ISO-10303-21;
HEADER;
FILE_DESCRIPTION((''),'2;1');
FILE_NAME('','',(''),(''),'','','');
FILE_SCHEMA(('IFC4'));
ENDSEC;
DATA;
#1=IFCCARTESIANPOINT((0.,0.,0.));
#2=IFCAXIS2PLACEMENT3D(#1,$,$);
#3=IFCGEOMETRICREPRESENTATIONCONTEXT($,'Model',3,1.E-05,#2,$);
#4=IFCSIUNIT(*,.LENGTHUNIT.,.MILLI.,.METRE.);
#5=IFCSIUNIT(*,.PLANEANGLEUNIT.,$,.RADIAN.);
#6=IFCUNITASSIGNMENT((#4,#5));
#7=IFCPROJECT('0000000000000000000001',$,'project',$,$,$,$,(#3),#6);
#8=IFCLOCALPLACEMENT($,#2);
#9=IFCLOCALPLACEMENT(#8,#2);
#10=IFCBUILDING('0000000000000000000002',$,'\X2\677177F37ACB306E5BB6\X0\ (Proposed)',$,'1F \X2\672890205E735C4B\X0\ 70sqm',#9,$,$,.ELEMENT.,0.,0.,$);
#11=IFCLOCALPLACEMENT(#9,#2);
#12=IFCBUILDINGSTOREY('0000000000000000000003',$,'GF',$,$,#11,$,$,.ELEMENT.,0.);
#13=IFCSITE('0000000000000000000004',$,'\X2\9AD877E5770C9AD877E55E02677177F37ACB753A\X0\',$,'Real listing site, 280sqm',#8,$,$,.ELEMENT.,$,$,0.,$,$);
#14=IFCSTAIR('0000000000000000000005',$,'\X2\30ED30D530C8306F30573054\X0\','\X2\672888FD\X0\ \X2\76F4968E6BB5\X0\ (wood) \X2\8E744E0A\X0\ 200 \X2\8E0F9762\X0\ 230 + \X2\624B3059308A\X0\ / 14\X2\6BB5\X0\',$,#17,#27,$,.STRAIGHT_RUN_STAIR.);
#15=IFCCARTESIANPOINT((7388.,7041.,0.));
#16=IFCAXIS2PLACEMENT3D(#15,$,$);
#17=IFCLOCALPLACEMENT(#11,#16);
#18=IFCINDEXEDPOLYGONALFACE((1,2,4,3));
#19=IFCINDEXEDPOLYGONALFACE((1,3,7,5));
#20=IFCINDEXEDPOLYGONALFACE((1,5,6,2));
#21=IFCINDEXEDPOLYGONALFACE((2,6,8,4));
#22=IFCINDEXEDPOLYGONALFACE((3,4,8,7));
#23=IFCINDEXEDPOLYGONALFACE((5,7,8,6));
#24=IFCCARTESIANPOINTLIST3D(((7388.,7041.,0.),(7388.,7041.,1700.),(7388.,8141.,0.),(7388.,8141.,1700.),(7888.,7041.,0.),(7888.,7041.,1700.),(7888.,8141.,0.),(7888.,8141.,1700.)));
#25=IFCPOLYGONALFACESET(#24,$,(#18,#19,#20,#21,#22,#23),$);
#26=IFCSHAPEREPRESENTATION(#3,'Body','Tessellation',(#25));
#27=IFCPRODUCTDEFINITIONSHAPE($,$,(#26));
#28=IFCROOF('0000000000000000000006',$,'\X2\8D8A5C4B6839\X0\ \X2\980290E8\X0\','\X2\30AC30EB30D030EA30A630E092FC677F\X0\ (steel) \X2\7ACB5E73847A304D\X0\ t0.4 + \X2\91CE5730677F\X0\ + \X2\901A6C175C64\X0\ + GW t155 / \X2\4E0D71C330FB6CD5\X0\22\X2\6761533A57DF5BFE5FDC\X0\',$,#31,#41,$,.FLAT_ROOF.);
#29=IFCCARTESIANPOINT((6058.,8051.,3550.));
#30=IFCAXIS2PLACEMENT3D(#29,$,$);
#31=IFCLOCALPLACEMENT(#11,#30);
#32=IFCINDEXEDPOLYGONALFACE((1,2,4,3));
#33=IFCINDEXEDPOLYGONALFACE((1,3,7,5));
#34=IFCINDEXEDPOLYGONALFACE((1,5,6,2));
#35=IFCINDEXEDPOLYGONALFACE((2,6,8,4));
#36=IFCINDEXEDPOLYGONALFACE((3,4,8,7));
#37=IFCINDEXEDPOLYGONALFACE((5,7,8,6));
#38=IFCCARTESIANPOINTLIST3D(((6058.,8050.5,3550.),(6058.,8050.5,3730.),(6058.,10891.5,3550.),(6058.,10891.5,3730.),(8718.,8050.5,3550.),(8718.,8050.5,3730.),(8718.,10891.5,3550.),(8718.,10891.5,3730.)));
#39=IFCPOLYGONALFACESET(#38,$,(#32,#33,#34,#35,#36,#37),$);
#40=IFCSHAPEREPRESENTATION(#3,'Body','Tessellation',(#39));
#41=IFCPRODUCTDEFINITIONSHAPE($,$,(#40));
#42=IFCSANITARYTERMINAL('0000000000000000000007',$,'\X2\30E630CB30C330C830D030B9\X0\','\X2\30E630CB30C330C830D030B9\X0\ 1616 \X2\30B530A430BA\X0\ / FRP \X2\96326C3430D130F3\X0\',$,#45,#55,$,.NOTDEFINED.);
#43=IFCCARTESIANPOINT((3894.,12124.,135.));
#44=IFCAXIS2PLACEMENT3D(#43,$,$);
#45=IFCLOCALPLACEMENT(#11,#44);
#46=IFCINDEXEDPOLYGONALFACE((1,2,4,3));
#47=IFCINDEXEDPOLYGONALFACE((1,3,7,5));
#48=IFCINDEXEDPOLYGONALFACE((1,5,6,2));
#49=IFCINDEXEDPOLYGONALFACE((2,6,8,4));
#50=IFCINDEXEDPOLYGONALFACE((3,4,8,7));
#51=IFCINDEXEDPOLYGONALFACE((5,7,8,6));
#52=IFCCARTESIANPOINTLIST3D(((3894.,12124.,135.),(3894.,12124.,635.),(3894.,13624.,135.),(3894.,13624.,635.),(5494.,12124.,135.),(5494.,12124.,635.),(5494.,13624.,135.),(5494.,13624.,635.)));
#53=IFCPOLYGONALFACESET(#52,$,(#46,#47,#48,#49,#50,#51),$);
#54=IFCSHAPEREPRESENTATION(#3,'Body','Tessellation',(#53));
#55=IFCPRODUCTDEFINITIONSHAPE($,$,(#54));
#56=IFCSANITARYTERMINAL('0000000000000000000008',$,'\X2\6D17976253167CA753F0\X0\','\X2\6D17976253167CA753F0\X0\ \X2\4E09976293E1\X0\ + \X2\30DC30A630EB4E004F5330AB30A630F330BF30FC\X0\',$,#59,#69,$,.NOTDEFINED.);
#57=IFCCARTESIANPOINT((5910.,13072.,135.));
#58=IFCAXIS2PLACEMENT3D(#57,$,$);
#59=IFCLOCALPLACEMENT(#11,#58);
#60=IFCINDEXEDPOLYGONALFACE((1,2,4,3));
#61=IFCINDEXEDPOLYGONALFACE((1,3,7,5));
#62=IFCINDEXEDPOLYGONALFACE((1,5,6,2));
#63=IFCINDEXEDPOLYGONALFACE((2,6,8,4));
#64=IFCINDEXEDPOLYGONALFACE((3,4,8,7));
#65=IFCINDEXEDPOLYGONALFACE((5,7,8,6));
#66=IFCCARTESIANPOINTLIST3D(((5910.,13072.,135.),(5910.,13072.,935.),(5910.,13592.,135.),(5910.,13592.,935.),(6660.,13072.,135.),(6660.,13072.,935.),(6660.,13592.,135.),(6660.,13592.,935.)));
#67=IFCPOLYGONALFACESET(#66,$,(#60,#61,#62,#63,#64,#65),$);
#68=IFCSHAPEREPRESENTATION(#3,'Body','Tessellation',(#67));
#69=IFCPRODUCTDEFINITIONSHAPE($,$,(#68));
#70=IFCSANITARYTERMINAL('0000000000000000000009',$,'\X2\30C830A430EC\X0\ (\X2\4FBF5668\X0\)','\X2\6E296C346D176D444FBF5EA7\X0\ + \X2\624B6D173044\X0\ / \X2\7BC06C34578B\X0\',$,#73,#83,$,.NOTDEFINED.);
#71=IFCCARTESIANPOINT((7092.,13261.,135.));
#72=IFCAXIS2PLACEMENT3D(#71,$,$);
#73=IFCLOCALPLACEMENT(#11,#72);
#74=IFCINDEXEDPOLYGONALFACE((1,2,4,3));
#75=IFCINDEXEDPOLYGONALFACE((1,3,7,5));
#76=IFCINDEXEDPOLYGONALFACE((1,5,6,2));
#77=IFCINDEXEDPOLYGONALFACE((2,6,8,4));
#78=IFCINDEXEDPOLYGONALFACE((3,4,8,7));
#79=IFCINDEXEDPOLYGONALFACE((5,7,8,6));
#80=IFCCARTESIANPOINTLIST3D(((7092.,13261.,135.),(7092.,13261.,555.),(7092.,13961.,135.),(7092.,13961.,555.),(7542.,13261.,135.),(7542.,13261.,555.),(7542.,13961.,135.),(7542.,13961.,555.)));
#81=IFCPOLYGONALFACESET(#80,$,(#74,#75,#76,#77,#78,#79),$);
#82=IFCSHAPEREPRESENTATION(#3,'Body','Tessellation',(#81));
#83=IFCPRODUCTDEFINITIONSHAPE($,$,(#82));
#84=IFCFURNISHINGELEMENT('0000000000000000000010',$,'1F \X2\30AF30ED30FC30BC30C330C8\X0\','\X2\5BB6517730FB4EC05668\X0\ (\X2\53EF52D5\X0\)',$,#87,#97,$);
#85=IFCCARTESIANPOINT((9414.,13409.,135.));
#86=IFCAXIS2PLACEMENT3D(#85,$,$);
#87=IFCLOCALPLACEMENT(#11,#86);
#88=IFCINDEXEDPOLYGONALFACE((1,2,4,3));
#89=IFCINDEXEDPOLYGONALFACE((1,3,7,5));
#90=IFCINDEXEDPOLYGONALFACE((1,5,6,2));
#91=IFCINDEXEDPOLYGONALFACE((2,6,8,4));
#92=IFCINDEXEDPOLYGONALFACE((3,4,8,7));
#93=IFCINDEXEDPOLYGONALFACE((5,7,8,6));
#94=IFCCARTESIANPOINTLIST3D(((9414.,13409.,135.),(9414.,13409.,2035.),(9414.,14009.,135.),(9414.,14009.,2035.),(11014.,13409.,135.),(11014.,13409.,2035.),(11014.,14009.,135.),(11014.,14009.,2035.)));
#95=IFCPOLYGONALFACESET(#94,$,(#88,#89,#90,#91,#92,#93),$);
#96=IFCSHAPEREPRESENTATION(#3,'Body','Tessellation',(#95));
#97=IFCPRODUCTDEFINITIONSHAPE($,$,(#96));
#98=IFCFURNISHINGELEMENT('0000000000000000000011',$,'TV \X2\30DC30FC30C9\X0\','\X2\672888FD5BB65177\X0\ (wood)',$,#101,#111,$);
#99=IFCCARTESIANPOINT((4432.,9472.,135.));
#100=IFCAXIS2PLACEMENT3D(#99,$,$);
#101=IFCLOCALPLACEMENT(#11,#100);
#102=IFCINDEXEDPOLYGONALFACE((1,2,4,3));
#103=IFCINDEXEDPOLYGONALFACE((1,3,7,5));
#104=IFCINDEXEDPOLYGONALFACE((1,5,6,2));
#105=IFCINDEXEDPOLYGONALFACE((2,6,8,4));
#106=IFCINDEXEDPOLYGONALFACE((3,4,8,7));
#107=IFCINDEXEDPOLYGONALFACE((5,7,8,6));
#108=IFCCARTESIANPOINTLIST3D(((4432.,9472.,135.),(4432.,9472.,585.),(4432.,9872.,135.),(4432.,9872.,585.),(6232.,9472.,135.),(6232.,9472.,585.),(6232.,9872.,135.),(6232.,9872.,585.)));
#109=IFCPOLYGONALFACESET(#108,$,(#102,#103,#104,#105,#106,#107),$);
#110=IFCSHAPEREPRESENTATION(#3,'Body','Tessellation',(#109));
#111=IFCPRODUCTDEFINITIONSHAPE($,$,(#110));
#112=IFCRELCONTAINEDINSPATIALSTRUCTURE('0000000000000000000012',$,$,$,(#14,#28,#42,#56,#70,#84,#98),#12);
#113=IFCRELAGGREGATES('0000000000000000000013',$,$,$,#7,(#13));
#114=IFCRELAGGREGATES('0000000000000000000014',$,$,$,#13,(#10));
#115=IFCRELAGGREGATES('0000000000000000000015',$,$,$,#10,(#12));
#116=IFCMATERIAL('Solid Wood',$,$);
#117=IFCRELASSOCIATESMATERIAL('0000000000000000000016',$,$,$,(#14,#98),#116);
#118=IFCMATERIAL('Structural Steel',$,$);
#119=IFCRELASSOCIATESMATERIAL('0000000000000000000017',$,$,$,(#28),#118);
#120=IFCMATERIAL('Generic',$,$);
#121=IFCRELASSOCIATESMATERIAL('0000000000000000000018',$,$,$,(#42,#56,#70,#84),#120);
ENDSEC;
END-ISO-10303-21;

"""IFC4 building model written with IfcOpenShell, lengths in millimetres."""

from ifc_helpers import new_model, si_unit, frame, frame_2d, origin, place, context, project, spatial, rectangle, extrude, material, element, save


model = new_model("IFC4")

# Units and contexts
model_context = context("Model", 3, precision=1e-05, world=origin())
ifc_project = project(units=[si_unit("LENGTHUNIT", "METRE", prefix="MILLI"), si_unit("PLANEANGLEUNIT", "RADIAN")], contexts=[model_context])

# Site, building, storey
site_placement = place(None, origin())
site = spatial("IfcSite", under=ifc_project, at=site_placement, Name="高知県高知市東石立町", ObjectType="Real listing site, 280sqm", CompositionType="ELEMENT", RefElevation=0.0)
building_placement = place(site_placement, origin())
building = spatial("IfcBuilding", under=site, at=building_placement, Name="東石立の家 (Proposed)", ObjectType="1F 木造平屋 70sqm", CompositionType="ELEMENT", ElevationOfRefHeight=0.0, ElevationOfTerrain=0.0)
storey_placement = place(building_placement, origin())
storey = spatial("IfcBuildingStorey", under=building, at=storey_placement, Name="GF", CompositionType="ELEMENT", Elevation=0.0)

# Shared definitions
ifc_material_1 = material(Name="Solid Wood")

# Stair
stair_placement = place(storey_placement, frame((7388.0, 7041.0, 0.0)))
element("IfcStair", 1, at=stair_placement, inside=storey, material=ifc_material_1, Name="ロフトはしご", Description="木製 直階段 (wood) 蹴上 200 踏面 230 + 手すり / 14段", PredefinedType="STRAIGHT_RUN_STAIR", context=model_context, shape_type="SweptSolid", body=[
    extrude(rectangle(XDim=500.0, YDim=1100.0, at=frame_2d((250.0, 550.0))), frame((7388.0, 7041.0, 0.0)), (0.0, 0.0, 1.0), 1700.0),
])

# Roof
ifc_material_2 = material(Name="Structural Steel")
roof_placement = place(storey_placement, frame((6058.0, 8051.0, 3550.0)))
element("IfcRoof", 2, at=roof_placement, inside=storey, material=ifc_material_2, Name="越屋根 頂部", Description="ガルバリウム鋼板 (steel) 立平葺き t0.4 + 野地板 + 通気層 + GW t155 / 不燃・法22条区域対応", PredefinedType="FLAT_ROOF", context=model_context, shape_type="SweptSolid", body=[
    extrude(rectangle(XDim=2660.0, YDim=2841.0, at=frame_2d((1330.0, 1420.0))), frame((6058.0, 8051.0, 3550.0)), (0.0, 0.0, 1.0), 180.0),
])

# Sanitary terminals
ifc_material_3 = material(Name="Generic")
sanitary_terminal_1_placement = place(storey_placement, frame((3894.0, 12124.0, 135.0)))
element("IfcSanitaryTerminal", 3, at=sanitary_terminal_1_placement, inside=storey, material=ifc_material_3, Name="ユニットバス", Description="ユニットバス 1616 サイズ / FRP 防水パン", PredefinedType="NOTDEFINED", context=model_context, shape_type="SweptSolid", body=[
    extrude(rectangle(XDim=1600.0, YDim=1500.0, at=frame_2d((800.0, 750.0))), frame((3894.0, 12124.0, 135.0)), (0.0, 0.0, 1.0), 500.0),
])
sanitary_terminal_2_placement = place(storey_placement, frame((5910.0, 13072.0, 135.0)))
element("IfcSanitaryTerminal", 4, at=sanitary_terminal_2_placement, inside=storey, material=ifc_material_3, Name="洗面化粧台", Description="洗面化粧台 三面鏡 + ボウル一体カウンター", PredefinedType="NOTDEFINED", context=model_context, shape_type="SweptSolid", body=[
    extrude(rectangle(XDim=750.0, YDim=520.0, at=frame_2d((375.0, 260.0))), frame((5910.0, 13072.0, 135.0)), (0.0, 0.0, 1.0), 800.0),
])
sanitary_terminal_3_placement = place(storey_placement, frame((7092.0, 13261.0, 135.0)))
element("IfcSanitaryTerminal", 5, at=sanitary_terminal_3_placement, inside=storey, material=ifc_material_3, Name="トイレ (便器)", Description="温水洗浄便座 + 手洗い / 節水型", PredefinedType="NOTDEFINED", context=model_context, shape_type="SweptSolid", body=[
    extrude(rectangle(XDim=450.0, YDim=700.0, at=frame_2d((225.0, 350.0))), frame((7092.0, 13261.0, 135.0)), (0.0, 0.0, 1.0), 420.0),
])

# Furnishing elements
furnishing_1_placement = place(storey_placement, frame((9414.0, 13409.0, 135.0)))
element("IfcFurnishingElement", 6, at=furnishing_1_placement, inside=storey, material=ifc_material_3, Name="1F クローゼット", Description="家具・什器 (可動)", context=model_context, shape_type="SweptSolid", body=[
    extrude(rectangle(XDim=1600.0, YDim=600.0, at=frame_2d((800.0, 300.0))), frame((9414.0, 13409.0, 135.0)), (0.0, 0.0, 1.0), 1900.0),
])
furnishing_2_placement = place(storey_placement, frame((4432.0, 9472.0, 135.0)))
element("IfcFurnishingElement", 7, at=furnishing_2_placement, inside=storey, material=ifc_material_1, Name="TV ボード", Description="木製家具 (wood)", context=model_context, shape_type="SweptSolid", body=[
    extrude(rectangle(XDim=1800.0, YDim=400.0, at=frame_2d((900.0, 200.0))), frame((4432.0, 9472.0, 135.0)), (0.0, 0.0, 1.0), 450.0),
])

save(model, "model.ifc")
